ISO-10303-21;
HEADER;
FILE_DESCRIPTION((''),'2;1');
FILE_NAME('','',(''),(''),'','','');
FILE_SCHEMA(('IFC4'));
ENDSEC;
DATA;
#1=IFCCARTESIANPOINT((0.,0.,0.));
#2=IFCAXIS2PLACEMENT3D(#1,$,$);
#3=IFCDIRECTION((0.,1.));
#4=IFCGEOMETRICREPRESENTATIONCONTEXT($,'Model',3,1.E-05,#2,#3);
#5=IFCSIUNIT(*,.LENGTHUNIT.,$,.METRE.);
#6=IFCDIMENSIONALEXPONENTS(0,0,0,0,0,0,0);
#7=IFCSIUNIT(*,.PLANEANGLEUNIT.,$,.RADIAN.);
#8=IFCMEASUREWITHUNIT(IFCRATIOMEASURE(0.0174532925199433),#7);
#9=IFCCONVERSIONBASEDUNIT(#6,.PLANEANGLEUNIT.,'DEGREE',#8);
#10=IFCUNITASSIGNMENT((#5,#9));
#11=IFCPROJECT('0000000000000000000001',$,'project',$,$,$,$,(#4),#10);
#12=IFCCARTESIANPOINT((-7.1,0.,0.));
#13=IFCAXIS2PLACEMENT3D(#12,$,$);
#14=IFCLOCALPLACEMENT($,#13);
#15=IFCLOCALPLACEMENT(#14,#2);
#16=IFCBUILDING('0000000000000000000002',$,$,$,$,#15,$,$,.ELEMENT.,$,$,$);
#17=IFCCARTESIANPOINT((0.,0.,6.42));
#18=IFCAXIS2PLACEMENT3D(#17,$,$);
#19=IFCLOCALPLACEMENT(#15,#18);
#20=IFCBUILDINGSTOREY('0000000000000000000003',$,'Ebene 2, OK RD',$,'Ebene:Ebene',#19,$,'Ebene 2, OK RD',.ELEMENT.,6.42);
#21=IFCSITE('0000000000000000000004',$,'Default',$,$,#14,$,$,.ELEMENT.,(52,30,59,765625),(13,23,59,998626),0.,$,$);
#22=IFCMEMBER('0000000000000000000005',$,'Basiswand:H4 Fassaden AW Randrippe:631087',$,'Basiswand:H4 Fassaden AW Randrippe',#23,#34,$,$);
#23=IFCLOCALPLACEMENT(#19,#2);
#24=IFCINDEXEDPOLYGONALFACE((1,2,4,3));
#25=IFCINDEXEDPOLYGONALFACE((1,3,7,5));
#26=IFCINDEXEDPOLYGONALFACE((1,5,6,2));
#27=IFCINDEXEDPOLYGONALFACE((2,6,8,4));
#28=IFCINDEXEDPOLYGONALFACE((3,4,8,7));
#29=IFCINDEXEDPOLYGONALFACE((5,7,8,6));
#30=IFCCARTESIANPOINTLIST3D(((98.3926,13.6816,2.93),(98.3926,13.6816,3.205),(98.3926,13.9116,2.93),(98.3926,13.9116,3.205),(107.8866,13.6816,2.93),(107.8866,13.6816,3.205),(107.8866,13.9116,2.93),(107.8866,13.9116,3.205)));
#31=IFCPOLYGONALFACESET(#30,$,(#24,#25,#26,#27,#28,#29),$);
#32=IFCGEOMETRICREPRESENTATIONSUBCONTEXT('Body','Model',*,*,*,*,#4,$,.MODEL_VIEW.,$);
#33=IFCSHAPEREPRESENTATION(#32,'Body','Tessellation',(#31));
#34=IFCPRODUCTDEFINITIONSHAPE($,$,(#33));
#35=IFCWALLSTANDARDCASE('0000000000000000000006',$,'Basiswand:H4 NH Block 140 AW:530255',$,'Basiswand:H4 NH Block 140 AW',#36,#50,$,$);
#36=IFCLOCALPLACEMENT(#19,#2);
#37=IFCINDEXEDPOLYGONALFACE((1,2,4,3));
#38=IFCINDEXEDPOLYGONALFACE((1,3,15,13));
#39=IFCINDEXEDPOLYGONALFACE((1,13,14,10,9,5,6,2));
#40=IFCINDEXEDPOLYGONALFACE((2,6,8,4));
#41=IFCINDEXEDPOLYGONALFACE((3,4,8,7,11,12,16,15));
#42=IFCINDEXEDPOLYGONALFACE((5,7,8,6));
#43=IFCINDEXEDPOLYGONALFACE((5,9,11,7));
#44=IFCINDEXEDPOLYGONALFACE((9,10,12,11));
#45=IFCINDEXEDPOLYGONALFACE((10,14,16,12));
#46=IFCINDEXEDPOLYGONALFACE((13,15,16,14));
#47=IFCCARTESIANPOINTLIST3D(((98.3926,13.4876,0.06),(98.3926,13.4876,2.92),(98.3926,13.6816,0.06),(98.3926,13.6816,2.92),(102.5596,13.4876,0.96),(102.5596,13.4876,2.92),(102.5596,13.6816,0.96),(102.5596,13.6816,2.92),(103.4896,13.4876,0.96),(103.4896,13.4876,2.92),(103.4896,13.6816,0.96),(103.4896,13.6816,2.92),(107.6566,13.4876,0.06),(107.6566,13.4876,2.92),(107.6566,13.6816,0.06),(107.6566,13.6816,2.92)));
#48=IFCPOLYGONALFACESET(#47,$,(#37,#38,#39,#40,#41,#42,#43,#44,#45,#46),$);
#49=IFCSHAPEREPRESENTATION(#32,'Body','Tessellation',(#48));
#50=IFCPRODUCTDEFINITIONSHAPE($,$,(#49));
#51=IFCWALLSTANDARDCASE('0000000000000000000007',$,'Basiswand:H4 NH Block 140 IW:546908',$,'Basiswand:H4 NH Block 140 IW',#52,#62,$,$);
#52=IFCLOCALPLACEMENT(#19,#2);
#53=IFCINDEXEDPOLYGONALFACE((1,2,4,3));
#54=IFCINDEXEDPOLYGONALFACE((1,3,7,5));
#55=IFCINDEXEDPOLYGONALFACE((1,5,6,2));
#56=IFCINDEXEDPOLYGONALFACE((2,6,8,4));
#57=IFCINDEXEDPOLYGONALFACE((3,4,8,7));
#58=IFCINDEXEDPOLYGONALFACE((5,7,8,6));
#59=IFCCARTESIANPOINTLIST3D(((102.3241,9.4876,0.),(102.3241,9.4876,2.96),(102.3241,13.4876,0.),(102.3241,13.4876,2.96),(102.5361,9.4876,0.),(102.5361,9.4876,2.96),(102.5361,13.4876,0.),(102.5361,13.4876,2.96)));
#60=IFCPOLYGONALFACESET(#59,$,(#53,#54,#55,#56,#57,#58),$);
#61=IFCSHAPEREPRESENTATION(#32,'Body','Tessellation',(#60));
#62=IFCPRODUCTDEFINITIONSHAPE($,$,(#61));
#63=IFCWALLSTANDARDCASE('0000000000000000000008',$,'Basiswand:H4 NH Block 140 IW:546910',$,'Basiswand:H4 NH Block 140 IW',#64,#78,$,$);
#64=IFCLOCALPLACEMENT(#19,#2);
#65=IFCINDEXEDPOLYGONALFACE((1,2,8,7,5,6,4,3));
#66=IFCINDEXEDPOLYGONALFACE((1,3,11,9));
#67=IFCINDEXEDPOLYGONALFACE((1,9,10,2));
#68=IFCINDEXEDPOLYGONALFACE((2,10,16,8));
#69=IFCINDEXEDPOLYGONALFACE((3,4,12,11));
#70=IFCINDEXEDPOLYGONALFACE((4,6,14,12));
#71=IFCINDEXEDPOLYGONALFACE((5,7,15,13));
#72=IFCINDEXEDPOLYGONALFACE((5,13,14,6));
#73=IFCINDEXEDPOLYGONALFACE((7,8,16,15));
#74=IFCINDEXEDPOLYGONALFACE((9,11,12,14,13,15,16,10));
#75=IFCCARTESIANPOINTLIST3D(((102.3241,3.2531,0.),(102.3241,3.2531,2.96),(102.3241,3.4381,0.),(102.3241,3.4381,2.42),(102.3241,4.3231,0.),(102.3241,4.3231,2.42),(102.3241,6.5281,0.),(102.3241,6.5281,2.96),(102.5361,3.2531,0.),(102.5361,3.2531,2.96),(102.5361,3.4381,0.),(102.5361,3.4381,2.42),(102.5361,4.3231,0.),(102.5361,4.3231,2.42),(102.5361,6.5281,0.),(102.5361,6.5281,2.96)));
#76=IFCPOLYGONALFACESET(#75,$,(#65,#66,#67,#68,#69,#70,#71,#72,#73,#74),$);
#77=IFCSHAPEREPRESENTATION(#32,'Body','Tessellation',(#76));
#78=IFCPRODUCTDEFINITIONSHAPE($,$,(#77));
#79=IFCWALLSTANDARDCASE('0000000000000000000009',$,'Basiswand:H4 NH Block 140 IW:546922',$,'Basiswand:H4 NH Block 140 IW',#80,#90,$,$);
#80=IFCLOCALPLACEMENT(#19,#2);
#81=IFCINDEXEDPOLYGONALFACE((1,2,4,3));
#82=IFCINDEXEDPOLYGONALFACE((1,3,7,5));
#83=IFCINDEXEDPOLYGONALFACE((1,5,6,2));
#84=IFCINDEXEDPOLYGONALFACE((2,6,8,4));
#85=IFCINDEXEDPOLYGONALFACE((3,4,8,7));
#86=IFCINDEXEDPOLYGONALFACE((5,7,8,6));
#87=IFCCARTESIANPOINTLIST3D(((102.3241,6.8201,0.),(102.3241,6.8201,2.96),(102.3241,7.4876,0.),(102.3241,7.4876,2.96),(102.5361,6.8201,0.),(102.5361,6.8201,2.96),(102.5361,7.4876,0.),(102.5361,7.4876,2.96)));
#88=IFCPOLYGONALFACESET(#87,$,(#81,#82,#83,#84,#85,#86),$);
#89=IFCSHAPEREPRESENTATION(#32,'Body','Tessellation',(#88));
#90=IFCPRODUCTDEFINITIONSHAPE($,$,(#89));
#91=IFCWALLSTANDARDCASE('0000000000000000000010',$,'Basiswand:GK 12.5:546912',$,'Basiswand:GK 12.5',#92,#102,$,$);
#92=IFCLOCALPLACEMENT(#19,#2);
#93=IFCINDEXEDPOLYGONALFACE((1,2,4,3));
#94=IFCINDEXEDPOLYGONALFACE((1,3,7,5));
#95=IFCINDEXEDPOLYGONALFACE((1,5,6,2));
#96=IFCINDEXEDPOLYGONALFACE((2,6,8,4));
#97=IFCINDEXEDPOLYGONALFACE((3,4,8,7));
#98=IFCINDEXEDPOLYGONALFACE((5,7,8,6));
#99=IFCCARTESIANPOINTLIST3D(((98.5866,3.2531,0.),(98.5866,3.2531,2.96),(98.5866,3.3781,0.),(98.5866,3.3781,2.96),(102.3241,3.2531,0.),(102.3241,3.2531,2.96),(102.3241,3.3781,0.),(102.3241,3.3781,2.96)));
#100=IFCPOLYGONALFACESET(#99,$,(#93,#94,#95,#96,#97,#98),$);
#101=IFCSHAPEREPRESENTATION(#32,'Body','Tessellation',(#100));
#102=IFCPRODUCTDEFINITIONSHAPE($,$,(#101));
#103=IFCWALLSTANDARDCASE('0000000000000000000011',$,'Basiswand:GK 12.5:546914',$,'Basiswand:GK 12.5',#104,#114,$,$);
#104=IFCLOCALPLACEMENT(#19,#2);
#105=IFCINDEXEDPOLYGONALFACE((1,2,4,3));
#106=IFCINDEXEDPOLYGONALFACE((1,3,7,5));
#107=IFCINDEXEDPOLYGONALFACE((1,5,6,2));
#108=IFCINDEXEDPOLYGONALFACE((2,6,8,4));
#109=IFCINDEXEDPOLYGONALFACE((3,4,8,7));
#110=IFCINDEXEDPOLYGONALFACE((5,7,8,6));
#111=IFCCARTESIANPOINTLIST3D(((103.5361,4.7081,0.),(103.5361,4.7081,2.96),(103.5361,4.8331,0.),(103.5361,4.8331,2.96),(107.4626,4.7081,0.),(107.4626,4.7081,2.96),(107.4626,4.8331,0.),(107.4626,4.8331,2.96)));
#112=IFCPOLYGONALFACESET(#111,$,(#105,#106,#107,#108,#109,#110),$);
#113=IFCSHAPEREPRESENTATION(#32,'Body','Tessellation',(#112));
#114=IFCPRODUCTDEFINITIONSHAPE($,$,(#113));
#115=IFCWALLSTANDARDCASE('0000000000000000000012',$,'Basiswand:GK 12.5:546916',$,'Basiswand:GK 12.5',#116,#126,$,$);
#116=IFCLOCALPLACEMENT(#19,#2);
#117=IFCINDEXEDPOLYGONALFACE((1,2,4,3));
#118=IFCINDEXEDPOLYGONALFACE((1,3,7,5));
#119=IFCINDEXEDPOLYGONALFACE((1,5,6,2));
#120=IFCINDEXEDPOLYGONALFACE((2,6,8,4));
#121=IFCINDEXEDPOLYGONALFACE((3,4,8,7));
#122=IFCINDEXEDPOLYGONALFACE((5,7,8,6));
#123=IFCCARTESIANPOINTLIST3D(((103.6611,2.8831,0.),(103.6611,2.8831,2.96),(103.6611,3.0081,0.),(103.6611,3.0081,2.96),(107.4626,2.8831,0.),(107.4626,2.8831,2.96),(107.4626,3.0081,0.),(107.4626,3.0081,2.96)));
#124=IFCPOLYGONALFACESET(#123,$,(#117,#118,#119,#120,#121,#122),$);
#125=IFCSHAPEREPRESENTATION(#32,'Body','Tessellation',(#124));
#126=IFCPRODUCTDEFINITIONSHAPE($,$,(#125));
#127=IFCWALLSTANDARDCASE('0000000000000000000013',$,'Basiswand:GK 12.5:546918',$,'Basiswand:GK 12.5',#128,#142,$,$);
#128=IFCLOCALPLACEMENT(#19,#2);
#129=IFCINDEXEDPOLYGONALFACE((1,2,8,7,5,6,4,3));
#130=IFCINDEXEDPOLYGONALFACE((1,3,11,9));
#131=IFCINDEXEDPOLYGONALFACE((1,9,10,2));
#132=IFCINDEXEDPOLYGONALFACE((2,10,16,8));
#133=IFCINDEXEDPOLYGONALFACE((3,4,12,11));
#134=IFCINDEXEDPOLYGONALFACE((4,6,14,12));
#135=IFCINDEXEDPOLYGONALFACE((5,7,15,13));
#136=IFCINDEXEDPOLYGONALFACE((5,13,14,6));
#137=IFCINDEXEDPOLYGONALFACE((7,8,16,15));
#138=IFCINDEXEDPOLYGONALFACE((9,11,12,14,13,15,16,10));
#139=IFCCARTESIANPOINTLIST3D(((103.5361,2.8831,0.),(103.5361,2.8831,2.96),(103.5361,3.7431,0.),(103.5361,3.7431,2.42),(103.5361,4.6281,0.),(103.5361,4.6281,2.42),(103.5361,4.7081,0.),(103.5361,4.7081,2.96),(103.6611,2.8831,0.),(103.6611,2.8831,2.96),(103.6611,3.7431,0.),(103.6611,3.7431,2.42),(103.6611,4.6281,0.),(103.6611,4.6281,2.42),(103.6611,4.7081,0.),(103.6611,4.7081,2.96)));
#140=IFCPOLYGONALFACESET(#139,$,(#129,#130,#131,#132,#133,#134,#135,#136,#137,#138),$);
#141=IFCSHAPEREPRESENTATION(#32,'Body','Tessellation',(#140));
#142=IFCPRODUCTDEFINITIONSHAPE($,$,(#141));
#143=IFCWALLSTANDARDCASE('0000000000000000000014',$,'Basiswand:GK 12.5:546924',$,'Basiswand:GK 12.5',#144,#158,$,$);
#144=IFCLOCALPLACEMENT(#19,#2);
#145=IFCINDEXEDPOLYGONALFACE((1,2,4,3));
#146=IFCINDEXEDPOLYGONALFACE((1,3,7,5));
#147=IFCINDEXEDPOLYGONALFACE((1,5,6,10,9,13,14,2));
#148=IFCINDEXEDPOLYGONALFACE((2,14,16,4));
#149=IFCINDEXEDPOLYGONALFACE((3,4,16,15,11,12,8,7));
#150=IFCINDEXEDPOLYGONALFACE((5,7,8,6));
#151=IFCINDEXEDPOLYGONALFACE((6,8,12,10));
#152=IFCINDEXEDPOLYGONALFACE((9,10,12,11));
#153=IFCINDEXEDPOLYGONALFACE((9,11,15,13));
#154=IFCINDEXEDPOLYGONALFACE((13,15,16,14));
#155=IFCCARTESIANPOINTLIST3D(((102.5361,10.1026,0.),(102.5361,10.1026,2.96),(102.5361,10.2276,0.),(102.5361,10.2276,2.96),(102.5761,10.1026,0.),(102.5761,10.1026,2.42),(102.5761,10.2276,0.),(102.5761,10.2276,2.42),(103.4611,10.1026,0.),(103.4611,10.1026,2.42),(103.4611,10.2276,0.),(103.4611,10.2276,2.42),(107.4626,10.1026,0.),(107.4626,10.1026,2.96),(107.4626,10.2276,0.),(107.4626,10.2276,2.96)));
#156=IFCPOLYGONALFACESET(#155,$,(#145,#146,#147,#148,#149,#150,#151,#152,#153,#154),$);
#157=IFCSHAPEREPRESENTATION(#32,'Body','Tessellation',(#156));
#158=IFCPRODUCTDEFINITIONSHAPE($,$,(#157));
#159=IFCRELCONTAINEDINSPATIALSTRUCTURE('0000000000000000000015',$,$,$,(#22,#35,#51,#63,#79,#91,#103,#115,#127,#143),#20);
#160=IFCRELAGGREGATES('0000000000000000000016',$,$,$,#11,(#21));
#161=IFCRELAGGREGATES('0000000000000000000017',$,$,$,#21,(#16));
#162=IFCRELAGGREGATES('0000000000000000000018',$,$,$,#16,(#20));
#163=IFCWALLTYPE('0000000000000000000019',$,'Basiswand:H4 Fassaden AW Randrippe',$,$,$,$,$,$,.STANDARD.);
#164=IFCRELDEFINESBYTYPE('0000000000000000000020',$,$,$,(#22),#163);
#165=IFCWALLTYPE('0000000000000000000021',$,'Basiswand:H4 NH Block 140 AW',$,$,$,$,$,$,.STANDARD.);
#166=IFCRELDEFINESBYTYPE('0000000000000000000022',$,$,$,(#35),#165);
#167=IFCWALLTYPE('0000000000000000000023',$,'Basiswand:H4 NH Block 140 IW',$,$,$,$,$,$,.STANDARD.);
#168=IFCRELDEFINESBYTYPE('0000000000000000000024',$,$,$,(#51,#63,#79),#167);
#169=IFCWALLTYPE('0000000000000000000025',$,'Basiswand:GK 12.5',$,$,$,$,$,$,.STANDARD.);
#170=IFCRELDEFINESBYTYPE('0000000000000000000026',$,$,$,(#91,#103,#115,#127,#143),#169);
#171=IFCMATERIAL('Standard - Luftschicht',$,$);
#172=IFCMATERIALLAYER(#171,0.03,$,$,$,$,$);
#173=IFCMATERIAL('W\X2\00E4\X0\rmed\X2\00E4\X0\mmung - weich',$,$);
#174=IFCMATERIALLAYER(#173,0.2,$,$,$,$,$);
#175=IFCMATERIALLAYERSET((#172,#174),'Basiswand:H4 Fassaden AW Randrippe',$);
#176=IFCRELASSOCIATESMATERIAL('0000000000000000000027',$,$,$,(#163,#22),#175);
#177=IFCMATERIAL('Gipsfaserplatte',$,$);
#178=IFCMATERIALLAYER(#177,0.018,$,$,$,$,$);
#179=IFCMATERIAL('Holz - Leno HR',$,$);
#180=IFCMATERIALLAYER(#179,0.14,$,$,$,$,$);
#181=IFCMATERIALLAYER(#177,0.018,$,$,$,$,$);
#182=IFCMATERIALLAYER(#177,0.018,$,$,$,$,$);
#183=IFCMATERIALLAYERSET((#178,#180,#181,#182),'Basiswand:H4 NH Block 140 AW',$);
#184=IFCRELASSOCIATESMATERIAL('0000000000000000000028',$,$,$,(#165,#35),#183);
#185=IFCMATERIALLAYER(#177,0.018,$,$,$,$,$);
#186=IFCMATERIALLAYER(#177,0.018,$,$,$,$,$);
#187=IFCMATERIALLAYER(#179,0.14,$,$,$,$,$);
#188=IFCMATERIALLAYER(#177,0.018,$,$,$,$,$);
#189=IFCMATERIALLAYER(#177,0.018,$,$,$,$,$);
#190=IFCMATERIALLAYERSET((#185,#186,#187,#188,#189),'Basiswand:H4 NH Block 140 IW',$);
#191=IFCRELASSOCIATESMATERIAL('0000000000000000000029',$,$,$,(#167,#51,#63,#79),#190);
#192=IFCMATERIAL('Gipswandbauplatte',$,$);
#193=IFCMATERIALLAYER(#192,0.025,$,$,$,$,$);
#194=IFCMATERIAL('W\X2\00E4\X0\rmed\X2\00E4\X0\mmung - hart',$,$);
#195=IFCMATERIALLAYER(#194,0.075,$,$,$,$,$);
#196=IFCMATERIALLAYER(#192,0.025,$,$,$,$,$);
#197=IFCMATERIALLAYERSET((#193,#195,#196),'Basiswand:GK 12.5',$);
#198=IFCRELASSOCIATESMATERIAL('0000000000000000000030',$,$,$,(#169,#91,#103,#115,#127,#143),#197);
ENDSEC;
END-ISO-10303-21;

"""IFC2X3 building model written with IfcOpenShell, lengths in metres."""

from ifc_helpers import new_model, entity, si_unit, converted_unit, direction, frame, frame_2d, origin, place, context, subcontext, project, spatial, rectangle, extrude, material, layer, layer_set, layer_usage, type_object, element, save


model = new_model("IFC2X3")

# Units and contexts
model_context = context("Model", 3, precision=1e-05, world=origin(), true_north=direction((0.0, 1.0)))
body_context = subcontext(model_context, "Body", "Model", "MODEL_VIEW")
ifc_project = project(units=[si_unit("LENGTHUNIT", "METRE"), converted_unit("PLANEANGLEUNIT", "DEGREE", entity("IfcRatioMeasure", 0.0174532925199433), si_unit("PLANEANGLEUNIT", "RADIAN"), dimensions=[0, 0, 0, 0, 0, 0, 0])], contexts=[model_context])

# Site, building, storey
site_placement = place(None, frame((-7.1, 0.0, 0.0)))
site = spatial("IfcSite", under=ifc_project, at=site_placement, Name="Default", CompositionType="ELEMENT", RefLatitude=(52, 30, 59, 765625), RefLongitude=(13, 23, 59, 998626), RefElevation=0.0)
building_placement = place(site_placement, origin())
building = spatial("IfcBuilding", under=site, at=building_placement, CompositionType="ELEMENT")
storey_placement = place(building_placement, frame((0.0, 0.0, 6.42)))
storey = spatial("IfcBuildingStorey", under=building, at=storey_placement, Name="Ebene 2, OK RD", ObjectType="Ebene:Ebene", LongName="Ebene 2, OK RD", CompositionType="ELEMENT", Elevation=6.42)

# Shared definitions
ifc_material_1 = material(Name="Gipsfaserplatte")

# Member
ifc_material_2 = material(Name="Standard - Luftschicht")
ifc_layer_1 = layer(ifc_material_2, 0.03)
ifc_material_3 = material(Name="Wärmedämmung - weich")
ifc_layer_2 = layer(ifc_material_3, 0.2)
ifc_layer_set_1 = layer_set([ifc_layer_1, ifc_layer_2], Name="Basiswand:H4 Fassaden AW Randrippe")
ifc_layer_usage_1 = layer_usage(ifc_layer_set_1, "AXIS2", "NEGATIVE", 0.115)
wall_type_1 = type_object("IfcWallType", Name="Basiswand:H4 Fassaden AW Randrippe", PredefinedType="STANDARD", material=ifc_layer_set_1)
member_1_placement = place(storey_placement, frame((98.3926, 13.7966, 2.93)))
element("IfcMember", 1, at=member_1_placement, inside=storey, type_object=wall_type_1, material=ifc_layer_usage_1, Name="Basiswand:H4 Fassaden AW Randrippe:631087", ObjectType="Basiswand:H4 Fassaden AW Randrippe", context=body_context, shape_type="SweptSolid", body=[
    extrude(rectangle(XDim=9.494, YDim=0.23, at=frame_2d((4.747, 0.0), x_axis=(-1.0, 0.0))), origin(), (0.0, 0.0, 1.0), 0.275),
])

# Wall, opening
ifc_layer_3 = layer(ifc_material_1, 0.018)
ifc_material_4 = material(Name="Holz - Leno HR")
ifc_layer_4 = layer(ifc_material_4, 0.14)
ifc_layer_5 = layer(ifc_material_1, 0.018)
ifc_layer_6 = layer(ifc_material_1, 0.018)
ifc_layer_set_2 = layer_set([ifc_layer_3, ifc_layer_4, ifc_layer_5, ifc_layer_6], Name="Basiswand:H4 NH Block 140 AW")
ifc_layer_usage_2 = layer_usage(ifc_layer_set_2, "AXIS2", "NEGATIVE", 0.097)
wall_type_2 = type_object("IfcWallType", Name="Basiswand:H4 NH Block 140 AW", PredefinedType="STANDARD", material=ifc_layer_set_2)
wall_1_placement = place(storey_placement, frame((98.3926, 13.5846, 0.06)))
wall_1 = element("IfcWallStandardCase", 2, at=wall_1_placement, inside=storey, type_object=wall_type_2, material=ifc_layer_usage_2, Name="Basiswand:H4 NH Block 140 AW:530255", ObjectType="Basiswand:H4 NH Block 140 AW", context=body_context, shape_type="SweptSolid", body=[
    extrude(rectangle(XDim=9.264, YDim=0.194, at=frame_2d((4.632, 0.0), x_axis=(-1.0, 0.0))), origin(), (0.0, 0.0, 1.0), 2.86),
])
opening_1_placement = place(wall_1_placement, origin())
element("IfcOpeningElement", 3, at=opening_1_placement, cuts=wall_1, ObjectType="Opening", context=body_context, shape_type="SweptSolid", body=[
    extrude(rectangle(XDim=2.0, YDim=0.93, at=frame_2d((0.0, 0.0), x_axis=(1.0, 0.0))), frame((4.632, -0.097, 1.9), z_axis=(0.0, 1.0, 0.0), x_axis=(0.0, 0.0, -1.0)), (0.0, 0.0, 1.0), 0.194),
])

# Wall
ifc_layer_7 = layer(ifc_material_1, 0.018)
ifc_layer_8 = layer(ifc_material_1, 0.018)
ifc_layer_9 = layer(ifc_material_4, 0.14)
ifc_layer_10 = layer(ifc_material_1, 0.018)
ifc_layer_11 = layer(ifc_material_1, 0.018)
ifc_layer_set_3 = layer_set([ifc_layer_7, ifc_layer_8, ifc_layer_9, ifc_layer_10, ifc_layer_11], Name="Basiswand:H4 NH Block 140 IW")
ifc_layer_usage_3 = layer_usage(ifc_layer_set_3, "AXIS2", "NEGATIVE", 0.106)
wall_type_3 = type_object("IfcWallType", Name="Basiswand:H4 NH Block 140 IW", PredefinedType="STANDARD", material=ifc_layer_set_3)
wall_2_placement = place(storey_placement, frame((102.4301, 13.4876, 0.0), z_axis=(0.0, 0.0, 1.0), x_axis=(0.0, -1.0, 0.0)))
element("IfcWallStandardCase", 4, at=wall_2_placement, inside=storey, type_object=wall_type_3, material=ifc_layer_usage_3, Name="Basiswand:H4 NH Block 140 IW:546908", ObjectType="Basiswand:H4 NH Block 140 IW", context=body_context, shape_type="SweptSolid", body=[
    extrude(rectangle(XDim=4.0, YDim=0.212, at=frame_2d((2.0, 0.0), x_axis=(-1.0, 0.0))), origin(), (0.0, 0.0, 1.0), 2.96),
])

# Wall, opening
ifc_layer_usage_4 = layer_usage(ifc_layer_set_3, "AXIS2", "NEGATIVE", 0.106)
wall_3_placement = place(storey_placement, frame((102.4301, 6.5281, 0.0), z_axis=(0.0, 0.0, 1.0), x_axis=(0.0, -1.0, 0.0)))
wall_3 = element("IfcWallStandardCase", 5, at=wall_3_placement, inside=storey, type_object=wall_type_3, material=ifc_layer_usage_4, Name="Basiswand:H4 NH Block 140 IW:546910", ObjectType="Basiswand:H4 NH Block 140 IW", context=body_context, shape_type="SweptSolid", body=[
    extrude(rectangle(XDim=3.275, YDim=0.212, at=frame_2d((1.6375, 0.0), x_axis=(-1.0, 0.0))), origin(), (0.0, 0.0, 1.0), 2.96),
])
opening_2_placement = place(wall_3_placement, frame((3.09, 0.106, 0.0)))
element("IfcOpeningElement", 6, at=opening_2_placement, cuts=wall_3, ObjectType="Opening", context=body_context, shape_type="SweptSolid", body=[
    extrude(rectangle(XDim=2.42, YDim=0.885, at=frame_2d((1.21, 0.4425), x_axis=(1.0, 0.0))), frame((0.0, 0.0, 0.0), z_axis=(0.0, -1.0, 0.0), x_axis=(0.0, 0.0, 1.0)), (0.0, 0.0, 1.0), 0.212),
])

# Walls
ifc_layer_usage_5 = layer_usage(ifc_layer_set_3, "AXIS2", "NEGATIVE", 0.106)
wall_4_placement = place(storey_placement, frame((102.4301, 7.4876, 0.0), z_axis=(0.0, 0.0, 1.0), x_axis=(0.0, -1.0, 0.0)))
element("IfcWallStandardCase", 7, at=wall_4_placement, inside=storey, type_object=wall_type_3, material=ifc_layer_usage_5, Name="Basiswand:H4 NH Block 140 IW:546922", ObjectType="Basiswand:H4 NH Block 140 IW", context=body_context, shape_type="SweptSolid", body=[
    extrude(rectangle(XDim=0.6675, YDim=0.212, at=frame_2d((0.3338, 0.0), x_axis=(-1.0, 0.0))), origin(), (0.0, 0.0, 1.0), 2.96),
])
ifc_material_5 = material(Name="Gipswandbauplatte")
ifc_layer_12 = layer(ifc_material_5, 0.025)
ifc_material_6 = material(Name="Wärmedämmung - hart")
ifc_layer_13 = layer(ifc_material_6, 0.075)
ifc_layer_14 = layer(ifc_material_5, 0.025)
ifc_layer_set_4 = layer_set([ifc_layer_12, ifc_layer_13, ifc_layer_14], Name="Basiswand:GK 12.5")
ifc_layer_usage_6 = layer_usage(ifc_layer_set_4, "AXIS2", "NEGATIVE", 0.0625)
wall_type_4 = type_object("IfcWallType", Name="Basiswand:GK 12.5", PredefinedType="STANDARD", material=ifc_layer_set_4)
wall_5_placement = place(storey_placement, frame((98.5866, 3.3156, 0.0)))
element("IfcWallStandardCase", 8, at=wall_5_placement, inside=storey, type_object=wall_type_4, material=ifc_layer_usage_6, Name="Basiswand:GK 12.5:546912", ObjectType="Basiswand:GK 12.5", context=body_context, shape_type="SweptSolid", body=[
    extrude(rectangle(XDim=3.7375, YDim=0.125, at=frame_2d((1.8687, 0.0), x_axis=(-1.0, 0.0))), origin(), (0.0, 0.0, 1.0), 2.96),
])
ifc_layer_usage_7 = layer_usage(ifc_layer_set_4, "AXIS2", "NEGATIVE", 0.0625)
wall_6_placement = place(storey_placement, frame((103.5361, 4.7706, 0.0)))
element("IfcWallStandardCase", 9, at=wall_6_placement, inside=storey, type_object=wall_type_4, material=ifc_layer_usage_7, Name="Basiswand:GK 12.5:546914", ObjectType="Basiswand:GK 12.5", context=body_context, shape_type="SweptSolid", body=[
    extrude(rectangle(XDim=3.9265, YDim=0.125, at=frame_2d((1.9633, 0.0), x_axis=(-1.0, 0.0))), origin(), (0.0, 0.0, 1.0), 2.96),
])
ifc_layer_usage_8 = layer_usage(ifc_layer_set_4, "AXIS2", "NEGATIVE", 0.0625)
wall_7_placement = place(storey_placement, frame((103.6611, 2.9456, 0.0)))
element("IfcWallStandardCase", 10, at=wall_7_placement, inside=storey, type_object=wall_type_4, material=ifc_layer_usage_8, Name="Basiswand:GK 12.5:546916", ObjectType="Basiswand:GK 12.5", context=body_context, shape_type="SweptSolid", body=[
    extrude(rectangle(XDim=3.8015, YDim=0.125, at=frame_2d((1.9008, 0.0), x_axis=(-1.0, 0.0))), origin(), (0.0, 0.0, 1.0), 2.96),
])

# Walls, openings
ifc_layer_usage_9 = layer_usage(ifc_layer_set_4, "AXIS2", "NEGATIVE", 0.0625)
wall_8_placement = place(storey_placement, frame((103.5986, 4.7081, 0.0), z_axis=(0.0, 0.0, 1.0), x_axis=(0.0, -1.0, 0.0)))
wall_8 = element("IfcWallStandardCase", 11, at=wall_8_placement, inside=storey, type_object=wall_type_4, material=ifc_layer_usage_9, Name="Basiswand:GK 12.5:546918", ObjectType="Basiswand:GK 12.5", context=body_context, shape_type="SweptSolid", body=[
    extrude(rectangle(XDim=1.825, YDim=0.125, at=frame_2d((0.9125, 0.0), x_axis=(-1.0, 0.0))), origin(), (0.0, 0.0, 1.0), 2.96),
])
opening_3_placement = place(wall_8_placement, frame((0.08, -0.0625, 0.0)))
element("IfcOpeningElement", 12, at=opening_3_placement, cuts=wall_8, ObjectType="Opening", context=body_context, shape_type="SweptSolid", body=[
    extrude(rectangle(XDim=2.42, YDim=0.885, at=frame_2d((1.21, 0.4425), x_axis=(1.0, 0.0))), frame((0.0, 0.0, 0.0), z_axis=(0.0, 1.0, 0.0), x_axis=(0.0, 0.0, 1.0)), (0.0, 0.0, 1.0), 0.125),
])
ifc_layer_usage_10 = layer_usage(ifc_layer_set_4, "AXIS2", "NEGATIVE", 0.0625)
wall_9_placement = place(storey_placement, frame((102.5361, 10.1651, 0.0)))
wall_9 = element("IfcWallStandardCase", 13, at=wall_9_placement, inside=storey, type_object=wall_type_4, material=ifc_layer_usage_10, Name="Basiswand:GK 12.5:546924", ObjectType="Basiswand:GK 12.5", context=body_context, shape_type="SweptSolid", body=[
    extrude(rectangle(XDim=4.9265, YDim=0.125, at=frame_2d((2.4633, 0.0), x_axis=(-1.0, 0.0))), origin(), (0.0, 0.0, 1.0), 2.96),
])
opening_4_placement = place(wall_9_placement, frame((0.04, -0.0625, 0.0)))
element("IfcOpeningElement", 14, at=opening_4_placement, cuts=wall_9, ObjectType="Opening", context=body_context, shape_type="SweptSolid", body=[
    extrude(rectangle(XDim=2.42, YDim=0.885, at=frame_2d((1.21, 0.4425), x_axis=(1.0, 0.0))), frame((0.0, 0.0, 0.0), z_axis=(0.0, 1.0, 0.0), x_axis=(0.0, 0.0, 1.0)), (0.0, 0.0, 1.0), 0.125),
])

save(model, "model.ifc")
